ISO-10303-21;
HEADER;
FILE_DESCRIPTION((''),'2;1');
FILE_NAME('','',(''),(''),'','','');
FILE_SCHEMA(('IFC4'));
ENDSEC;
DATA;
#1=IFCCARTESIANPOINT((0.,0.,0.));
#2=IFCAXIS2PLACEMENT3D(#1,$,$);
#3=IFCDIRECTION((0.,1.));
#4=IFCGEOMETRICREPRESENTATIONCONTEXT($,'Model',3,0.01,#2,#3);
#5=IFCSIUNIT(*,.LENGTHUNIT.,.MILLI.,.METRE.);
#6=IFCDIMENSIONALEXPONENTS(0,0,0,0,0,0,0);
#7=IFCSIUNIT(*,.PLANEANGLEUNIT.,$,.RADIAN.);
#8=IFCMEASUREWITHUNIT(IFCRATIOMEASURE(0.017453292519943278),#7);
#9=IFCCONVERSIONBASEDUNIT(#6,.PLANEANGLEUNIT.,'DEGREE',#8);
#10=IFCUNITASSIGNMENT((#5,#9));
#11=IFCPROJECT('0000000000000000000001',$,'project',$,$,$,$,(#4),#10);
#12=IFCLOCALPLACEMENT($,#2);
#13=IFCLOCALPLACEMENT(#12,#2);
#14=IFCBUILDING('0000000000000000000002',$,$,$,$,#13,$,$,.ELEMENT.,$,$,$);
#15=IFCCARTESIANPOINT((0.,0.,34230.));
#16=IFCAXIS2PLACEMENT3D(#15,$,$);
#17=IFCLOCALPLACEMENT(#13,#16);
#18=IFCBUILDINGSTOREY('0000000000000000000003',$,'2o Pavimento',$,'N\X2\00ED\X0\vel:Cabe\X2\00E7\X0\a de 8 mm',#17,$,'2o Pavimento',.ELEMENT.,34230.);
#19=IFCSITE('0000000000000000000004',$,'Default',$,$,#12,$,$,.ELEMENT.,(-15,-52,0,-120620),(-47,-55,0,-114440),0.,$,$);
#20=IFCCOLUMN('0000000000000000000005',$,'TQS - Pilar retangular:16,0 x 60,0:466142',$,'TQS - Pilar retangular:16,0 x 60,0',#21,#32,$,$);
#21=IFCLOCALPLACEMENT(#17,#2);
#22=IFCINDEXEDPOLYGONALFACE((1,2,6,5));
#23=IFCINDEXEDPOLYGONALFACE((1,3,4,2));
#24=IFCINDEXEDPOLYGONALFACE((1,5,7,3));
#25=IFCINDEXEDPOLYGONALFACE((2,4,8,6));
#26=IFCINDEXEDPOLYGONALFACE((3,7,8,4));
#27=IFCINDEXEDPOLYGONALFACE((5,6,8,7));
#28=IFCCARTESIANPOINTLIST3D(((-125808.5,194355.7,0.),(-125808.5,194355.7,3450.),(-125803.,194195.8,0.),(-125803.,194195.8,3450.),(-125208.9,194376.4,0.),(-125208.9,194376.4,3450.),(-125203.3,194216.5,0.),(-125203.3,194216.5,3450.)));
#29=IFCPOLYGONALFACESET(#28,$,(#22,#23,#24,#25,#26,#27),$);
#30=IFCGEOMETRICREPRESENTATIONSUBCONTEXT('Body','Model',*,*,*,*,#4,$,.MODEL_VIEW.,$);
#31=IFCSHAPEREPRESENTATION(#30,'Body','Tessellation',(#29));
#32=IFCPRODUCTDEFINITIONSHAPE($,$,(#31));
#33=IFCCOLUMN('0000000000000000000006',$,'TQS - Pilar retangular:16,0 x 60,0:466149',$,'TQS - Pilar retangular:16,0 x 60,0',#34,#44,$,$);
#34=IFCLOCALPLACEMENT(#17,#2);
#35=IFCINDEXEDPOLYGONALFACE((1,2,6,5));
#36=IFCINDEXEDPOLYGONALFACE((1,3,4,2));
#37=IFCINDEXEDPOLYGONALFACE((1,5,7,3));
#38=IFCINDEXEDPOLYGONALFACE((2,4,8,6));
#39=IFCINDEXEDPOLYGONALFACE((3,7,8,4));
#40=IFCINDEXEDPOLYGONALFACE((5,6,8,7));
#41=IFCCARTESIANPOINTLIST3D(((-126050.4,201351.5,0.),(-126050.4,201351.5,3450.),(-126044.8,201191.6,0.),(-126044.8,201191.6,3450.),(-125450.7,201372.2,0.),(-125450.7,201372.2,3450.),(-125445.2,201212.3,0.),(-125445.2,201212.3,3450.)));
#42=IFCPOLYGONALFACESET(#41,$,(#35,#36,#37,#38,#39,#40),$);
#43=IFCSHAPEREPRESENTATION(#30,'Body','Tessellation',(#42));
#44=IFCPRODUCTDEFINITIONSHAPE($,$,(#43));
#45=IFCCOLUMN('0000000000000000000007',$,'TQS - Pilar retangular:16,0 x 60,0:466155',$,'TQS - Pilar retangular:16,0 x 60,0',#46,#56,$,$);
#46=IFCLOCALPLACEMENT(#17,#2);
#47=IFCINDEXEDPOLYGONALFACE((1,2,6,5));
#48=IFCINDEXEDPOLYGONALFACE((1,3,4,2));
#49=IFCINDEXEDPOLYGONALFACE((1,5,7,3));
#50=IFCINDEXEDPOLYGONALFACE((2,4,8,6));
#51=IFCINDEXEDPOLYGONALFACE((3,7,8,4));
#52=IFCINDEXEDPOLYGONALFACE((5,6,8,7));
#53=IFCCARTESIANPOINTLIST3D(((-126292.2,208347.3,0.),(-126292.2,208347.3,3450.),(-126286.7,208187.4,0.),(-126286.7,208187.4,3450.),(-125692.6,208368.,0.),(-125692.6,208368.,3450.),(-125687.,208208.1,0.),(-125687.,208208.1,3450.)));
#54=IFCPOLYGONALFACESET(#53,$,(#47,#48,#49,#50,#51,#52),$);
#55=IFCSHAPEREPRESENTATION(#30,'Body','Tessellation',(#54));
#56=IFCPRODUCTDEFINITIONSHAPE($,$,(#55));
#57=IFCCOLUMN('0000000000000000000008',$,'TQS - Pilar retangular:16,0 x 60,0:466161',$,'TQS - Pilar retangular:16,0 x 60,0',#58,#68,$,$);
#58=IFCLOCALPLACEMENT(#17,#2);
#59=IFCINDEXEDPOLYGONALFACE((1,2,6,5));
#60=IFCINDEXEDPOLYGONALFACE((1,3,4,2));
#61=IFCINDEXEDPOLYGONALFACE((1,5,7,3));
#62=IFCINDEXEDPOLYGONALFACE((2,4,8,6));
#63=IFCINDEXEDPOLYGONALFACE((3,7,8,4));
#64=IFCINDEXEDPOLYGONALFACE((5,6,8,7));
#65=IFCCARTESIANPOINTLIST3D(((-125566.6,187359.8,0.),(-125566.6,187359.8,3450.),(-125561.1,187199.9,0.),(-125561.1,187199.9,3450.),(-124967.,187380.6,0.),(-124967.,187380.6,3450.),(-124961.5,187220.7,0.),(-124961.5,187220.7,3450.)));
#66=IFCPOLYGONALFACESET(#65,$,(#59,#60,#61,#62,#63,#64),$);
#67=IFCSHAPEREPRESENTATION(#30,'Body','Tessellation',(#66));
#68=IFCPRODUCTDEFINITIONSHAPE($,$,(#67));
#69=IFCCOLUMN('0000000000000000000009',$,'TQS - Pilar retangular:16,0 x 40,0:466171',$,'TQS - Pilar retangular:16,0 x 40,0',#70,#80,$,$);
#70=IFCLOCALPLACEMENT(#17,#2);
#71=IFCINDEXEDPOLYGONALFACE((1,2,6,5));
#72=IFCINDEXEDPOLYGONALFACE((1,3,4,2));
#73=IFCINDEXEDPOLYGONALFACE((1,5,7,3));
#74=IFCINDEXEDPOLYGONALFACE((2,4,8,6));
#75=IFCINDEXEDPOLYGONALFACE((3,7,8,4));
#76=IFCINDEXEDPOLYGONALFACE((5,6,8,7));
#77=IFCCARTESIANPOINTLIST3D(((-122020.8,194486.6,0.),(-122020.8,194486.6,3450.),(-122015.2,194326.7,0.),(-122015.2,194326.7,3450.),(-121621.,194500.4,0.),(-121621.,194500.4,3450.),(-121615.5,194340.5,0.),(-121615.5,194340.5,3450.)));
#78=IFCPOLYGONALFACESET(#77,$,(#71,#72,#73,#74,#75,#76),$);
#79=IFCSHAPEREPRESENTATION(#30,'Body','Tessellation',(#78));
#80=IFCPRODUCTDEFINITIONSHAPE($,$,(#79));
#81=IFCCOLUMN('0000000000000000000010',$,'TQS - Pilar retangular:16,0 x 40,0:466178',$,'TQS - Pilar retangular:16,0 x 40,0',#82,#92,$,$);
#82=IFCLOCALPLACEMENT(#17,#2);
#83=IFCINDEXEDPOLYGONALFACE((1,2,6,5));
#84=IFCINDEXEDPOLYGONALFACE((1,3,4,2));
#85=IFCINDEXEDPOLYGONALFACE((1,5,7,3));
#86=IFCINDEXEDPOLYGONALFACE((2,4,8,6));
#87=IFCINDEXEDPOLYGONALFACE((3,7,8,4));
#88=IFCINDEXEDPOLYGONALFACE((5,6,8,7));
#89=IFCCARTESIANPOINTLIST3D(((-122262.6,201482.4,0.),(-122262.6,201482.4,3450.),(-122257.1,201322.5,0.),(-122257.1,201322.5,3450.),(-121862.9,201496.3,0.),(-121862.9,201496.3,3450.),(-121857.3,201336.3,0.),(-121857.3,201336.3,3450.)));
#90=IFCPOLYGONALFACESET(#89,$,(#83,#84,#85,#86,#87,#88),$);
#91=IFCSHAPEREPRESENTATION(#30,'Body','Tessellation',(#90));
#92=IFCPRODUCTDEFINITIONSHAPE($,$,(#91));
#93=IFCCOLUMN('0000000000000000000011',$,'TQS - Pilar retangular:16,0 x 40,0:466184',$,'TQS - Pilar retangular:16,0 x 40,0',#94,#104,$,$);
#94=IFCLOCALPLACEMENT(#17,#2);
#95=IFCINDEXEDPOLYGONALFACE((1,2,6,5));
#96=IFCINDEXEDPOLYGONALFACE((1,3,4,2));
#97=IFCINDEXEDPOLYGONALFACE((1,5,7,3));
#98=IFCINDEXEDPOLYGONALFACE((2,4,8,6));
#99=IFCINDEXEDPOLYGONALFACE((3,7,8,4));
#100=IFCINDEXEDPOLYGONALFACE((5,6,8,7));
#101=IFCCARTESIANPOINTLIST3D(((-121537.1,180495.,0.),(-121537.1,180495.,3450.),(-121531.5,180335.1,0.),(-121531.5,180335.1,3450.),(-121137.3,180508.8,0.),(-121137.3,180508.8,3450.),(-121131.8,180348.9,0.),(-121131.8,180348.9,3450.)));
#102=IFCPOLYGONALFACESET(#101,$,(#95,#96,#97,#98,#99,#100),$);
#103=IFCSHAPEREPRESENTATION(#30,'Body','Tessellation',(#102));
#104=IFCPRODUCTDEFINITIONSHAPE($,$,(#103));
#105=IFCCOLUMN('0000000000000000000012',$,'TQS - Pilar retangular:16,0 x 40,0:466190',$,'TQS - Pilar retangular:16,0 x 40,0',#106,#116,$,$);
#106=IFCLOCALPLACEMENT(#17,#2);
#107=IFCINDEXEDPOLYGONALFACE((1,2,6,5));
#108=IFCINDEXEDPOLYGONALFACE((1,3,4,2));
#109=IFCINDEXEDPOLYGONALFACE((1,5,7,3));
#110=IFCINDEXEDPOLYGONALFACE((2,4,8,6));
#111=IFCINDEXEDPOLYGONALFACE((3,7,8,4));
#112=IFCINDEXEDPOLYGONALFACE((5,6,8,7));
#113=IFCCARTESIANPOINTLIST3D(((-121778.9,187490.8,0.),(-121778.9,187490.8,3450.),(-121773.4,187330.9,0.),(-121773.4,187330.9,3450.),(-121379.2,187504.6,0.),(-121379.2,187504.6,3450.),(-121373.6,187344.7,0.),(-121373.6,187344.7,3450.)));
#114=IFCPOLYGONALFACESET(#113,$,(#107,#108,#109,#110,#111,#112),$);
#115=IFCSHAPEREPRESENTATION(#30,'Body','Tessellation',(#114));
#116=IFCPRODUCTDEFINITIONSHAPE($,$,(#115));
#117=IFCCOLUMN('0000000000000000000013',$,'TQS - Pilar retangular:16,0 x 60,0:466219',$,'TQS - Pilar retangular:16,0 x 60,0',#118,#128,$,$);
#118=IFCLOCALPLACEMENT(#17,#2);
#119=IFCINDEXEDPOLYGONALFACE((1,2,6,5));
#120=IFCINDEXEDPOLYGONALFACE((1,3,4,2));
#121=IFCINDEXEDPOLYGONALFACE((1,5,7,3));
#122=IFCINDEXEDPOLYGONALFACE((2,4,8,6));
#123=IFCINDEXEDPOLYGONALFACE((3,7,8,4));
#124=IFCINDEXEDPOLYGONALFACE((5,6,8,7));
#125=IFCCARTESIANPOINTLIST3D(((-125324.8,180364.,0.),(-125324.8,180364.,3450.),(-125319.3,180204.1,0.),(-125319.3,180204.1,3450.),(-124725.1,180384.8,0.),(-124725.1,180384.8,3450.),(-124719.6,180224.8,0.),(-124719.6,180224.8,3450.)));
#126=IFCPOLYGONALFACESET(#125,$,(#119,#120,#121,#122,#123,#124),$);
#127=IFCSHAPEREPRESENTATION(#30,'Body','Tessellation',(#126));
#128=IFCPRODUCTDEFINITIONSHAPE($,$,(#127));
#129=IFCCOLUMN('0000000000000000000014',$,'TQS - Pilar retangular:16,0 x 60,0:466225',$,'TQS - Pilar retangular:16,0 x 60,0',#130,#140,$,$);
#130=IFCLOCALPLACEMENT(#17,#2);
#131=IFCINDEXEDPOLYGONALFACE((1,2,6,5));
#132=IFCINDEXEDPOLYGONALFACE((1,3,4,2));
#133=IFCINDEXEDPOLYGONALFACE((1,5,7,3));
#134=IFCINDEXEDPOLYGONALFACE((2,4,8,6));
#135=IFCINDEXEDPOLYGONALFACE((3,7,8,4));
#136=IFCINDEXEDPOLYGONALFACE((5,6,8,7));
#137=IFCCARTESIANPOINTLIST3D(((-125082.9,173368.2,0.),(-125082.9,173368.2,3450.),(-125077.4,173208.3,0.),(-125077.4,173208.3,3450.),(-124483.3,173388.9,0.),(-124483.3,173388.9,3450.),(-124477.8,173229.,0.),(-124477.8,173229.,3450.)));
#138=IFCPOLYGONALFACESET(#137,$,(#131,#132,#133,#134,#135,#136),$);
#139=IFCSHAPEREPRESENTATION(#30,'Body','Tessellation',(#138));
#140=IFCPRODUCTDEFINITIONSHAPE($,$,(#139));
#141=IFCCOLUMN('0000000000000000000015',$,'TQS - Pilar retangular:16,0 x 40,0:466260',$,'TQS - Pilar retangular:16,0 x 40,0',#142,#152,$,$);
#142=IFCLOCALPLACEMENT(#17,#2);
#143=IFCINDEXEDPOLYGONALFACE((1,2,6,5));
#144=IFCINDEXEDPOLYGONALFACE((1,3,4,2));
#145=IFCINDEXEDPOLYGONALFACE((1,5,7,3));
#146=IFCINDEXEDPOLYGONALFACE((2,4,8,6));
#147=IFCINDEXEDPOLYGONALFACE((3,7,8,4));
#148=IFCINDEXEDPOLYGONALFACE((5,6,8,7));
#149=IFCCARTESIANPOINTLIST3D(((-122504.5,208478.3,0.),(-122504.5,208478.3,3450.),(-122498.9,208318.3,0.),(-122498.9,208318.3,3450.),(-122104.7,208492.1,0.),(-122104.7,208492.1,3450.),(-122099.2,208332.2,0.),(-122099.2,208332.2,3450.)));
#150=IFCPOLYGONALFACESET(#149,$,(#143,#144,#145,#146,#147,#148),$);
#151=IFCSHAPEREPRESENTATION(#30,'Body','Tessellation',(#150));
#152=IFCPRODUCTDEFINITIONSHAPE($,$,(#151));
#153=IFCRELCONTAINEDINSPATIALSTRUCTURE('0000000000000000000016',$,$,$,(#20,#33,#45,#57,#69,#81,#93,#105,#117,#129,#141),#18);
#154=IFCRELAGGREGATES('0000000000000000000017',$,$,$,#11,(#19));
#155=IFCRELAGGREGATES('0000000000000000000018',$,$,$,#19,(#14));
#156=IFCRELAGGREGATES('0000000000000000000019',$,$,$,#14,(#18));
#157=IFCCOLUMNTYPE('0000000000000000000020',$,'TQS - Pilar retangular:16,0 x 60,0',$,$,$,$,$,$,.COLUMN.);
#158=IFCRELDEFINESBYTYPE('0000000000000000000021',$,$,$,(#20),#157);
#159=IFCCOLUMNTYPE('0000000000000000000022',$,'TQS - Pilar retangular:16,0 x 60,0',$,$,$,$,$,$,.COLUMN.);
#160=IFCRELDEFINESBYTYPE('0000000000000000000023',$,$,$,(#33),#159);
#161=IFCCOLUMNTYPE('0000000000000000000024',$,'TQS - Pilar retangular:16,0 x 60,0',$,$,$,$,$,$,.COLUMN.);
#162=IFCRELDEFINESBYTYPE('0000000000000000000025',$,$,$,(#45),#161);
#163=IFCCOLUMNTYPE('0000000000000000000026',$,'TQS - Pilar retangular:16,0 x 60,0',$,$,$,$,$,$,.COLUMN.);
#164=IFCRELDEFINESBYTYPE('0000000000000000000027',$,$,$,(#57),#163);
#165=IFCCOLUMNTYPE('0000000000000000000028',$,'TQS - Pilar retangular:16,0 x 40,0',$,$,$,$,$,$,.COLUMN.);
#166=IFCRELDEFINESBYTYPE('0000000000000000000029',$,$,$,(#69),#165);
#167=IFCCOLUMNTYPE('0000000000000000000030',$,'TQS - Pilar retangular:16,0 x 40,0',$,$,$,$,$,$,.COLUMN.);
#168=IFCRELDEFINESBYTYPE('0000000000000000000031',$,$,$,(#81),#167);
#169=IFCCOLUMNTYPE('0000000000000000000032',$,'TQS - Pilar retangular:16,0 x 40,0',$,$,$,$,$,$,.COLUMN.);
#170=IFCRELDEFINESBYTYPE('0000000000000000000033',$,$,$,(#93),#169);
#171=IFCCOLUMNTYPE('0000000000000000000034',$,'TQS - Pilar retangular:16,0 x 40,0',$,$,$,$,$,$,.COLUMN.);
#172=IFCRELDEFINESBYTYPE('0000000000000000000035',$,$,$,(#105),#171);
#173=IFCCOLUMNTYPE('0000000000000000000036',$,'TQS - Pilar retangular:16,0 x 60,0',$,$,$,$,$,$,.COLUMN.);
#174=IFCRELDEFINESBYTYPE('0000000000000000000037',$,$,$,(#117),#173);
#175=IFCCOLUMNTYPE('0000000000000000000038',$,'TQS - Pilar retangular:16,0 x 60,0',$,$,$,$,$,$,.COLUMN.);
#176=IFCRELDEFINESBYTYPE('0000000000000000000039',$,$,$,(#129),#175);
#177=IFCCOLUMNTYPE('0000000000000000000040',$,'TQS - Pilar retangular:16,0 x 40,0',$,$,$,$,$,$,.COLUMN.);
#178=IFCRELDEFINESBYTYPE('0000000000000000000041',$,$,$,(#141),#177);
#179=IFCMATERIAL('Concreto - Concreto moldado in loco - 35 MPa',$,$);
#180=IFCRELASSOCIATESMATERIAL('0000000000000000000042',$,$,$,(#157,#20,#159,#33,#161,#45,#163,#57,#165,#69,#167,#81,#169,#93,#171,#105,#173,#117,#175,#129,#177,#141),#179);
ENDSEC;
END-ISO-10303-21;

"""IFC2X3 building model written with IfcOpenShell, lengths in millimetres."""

from ifc_helpers import new_model, entity, si_unit, converted_unit, direction, frame, origin, origin_2d_with_axis, place, context, subcontext, project, spatial, rectangle, extrude, source, transform, mapped, material, type_object, type_shapes, element, save


model = new_model("IFC2X3")

# Units and contexts
model_context = context("Model", 3, precision=0.01, world=origin(), true_north=direction((0.0, 1.0)))
body_context = subcontext(model_context, "Body", "Model", "MODEL_VIEW")
ifc_project = project(units=[si_unit("LENGTHUNIT", "METRE", prefix="MILLI"), converted_unit("PLANEANGLEUNIT", "DEGREE", entity("IfcRatioMeasure", 0.017453292519943278), si_unit("PLANEANGLEUNIT", "RADIAN"), dimensions=[0, 0, 0, 0, 0, 0, 0])], contexts=[model_context])

# Site, building, storey
site_placement = place(None, origin())
site = spatial("IfcSite", under=ifc_project, at=site_placement, Name="Default", CompositionType="ELEMENT", RefLatitude=(-15, -52, 0, -120620), RefLongitude=(-47, -55, 0, -114440), RefElevation=0.0)
building_placement = place(site_placement, origin())
building = spatial("IfcBuilding", under=site, at=building_placement, CompositionType="ELEMENT")
storey_placement = place(building_placement, frame((0.0, 0.0, 34230.0)))
storey = spatial("IfcBuildingStorey", under=building, at=storey_placement, Name="2o Pavimento", ObjectType="Nível:Cabeça de 8 mm", LongName="2o Pavimento", CompositionType="ELEMENT", Elevation=34230.0)

# Columns
ifc_material = material(Name="Concreto - Concreto moldado in loco - 35 MPa")
column_type_1 = type_object("IfcColumnType", Name="TQS - Pilar retangular:16,0 x 60,0", PredefinedType="COLUMN", material=ifc_material)
shared_shape_1 = source(origin(), body_context, "Body", "SweptSolid", [
    extrude(rectangle(XDim=600.0, YDim=160.0, at=origin_2d_with_axis()), frame((-125505.9, 194286.1, 34230.0), z_axis=(0.0, 0.0, 1.0), x_axis=(-0.999403, -0.034551, 0.0)), (0.0, 0.0, 1.0), 3450.0),
])
type_shapes(column_type_1, [shared_shape_1])
column_1_placement = place(storey_placement, frame((0.0, 0.0, -34230.0)))
element("IfcColumn", 1, at=column_1_placement, inside=storey, type_object=column_type_1, material=ifc_material, Name="TQS - Pilar retangular:16,0 x 60,0:466142", ObjectType="TQS - Pilar retangular:16,0 x 60,0", context=body_context, shape_type="MappedRepresentation", body=[
    mapped(shared_shape_1, transform((0.0, 0.0, 0.0), scale=1.0)),
])
column_type_2 = type_object("IfcColumnType", Name="TQS - Pilar retangular:16,0 x 60,0", PredefinedType="COLUMN", material=ifc_material)
shared_shape_2 = source(origin(), body_context, "Body", "SweptSolid", [
    extrude(rectangle(XDim=600.0, YDim=160.0, at=origin_2d_with_axis()), frame((-125747.8, 201281.9, 34230.0), z_axis=(0.0, 0.0, 1.0), x_axis=(-0.999403, -0.034551, 0.0)), (0.0, 0.0, 1.0), 3450.0),
])
type_shapes(column_type_2, [shared_shape_2])
column_2_placement = place(storey_placement, frame((0.0, 0.0, -34230.0)))
element("IfcColumn", 2, at=column_2_placement, inside=storey, type_object=column_type_2, material=ifc_material, Name="TQS - Pilar retangular:16,0 x 60,0:466149", ObjectType="TQS - Pilar retangular:16,0 x 60,0", context=body_context, shape_type="MappedRepresentation", body=[
    mapped(shared_shape_2, transform((0.0, 0.0, 0.0), scale=1.0)),
])
column_type_3 = type_object("IfcColumnType", Name="TQS - Pilar retangular:16,0 x 60,0", PredefinedType="COLUMN", material=ifc_material)
shared_shape_3 = source(origin(), body_context, "Body", "SweptSolid", [
    extrude(rectangle(XDim=600.0, YDim=160.0, at=origin_2d_with_axis()), frame((-125989.6, 208277.7, 34230.0), z_axis=(0.0, 0.0, 1.0), x_axis=(-0.999403, -0.034551, 0.0)), (0.0, 0.0, 1.0), 3450.0),
])
type_shapes(column_type_3, [shared_shape_3])
column_3_placement = place(storey_placement, frame((0.0, 0.0, -34230.0)))
element("IfcColumn", 3, at=column_3_placement, inside=storey, type_object=column_type_3, material=ifc_material, Name="TQS - Pilar retangular:16,0 x 60,0:466155", ObjectType="TQS - Pilar retangular:16,0 x 60,0", context=body_context, shape_type="MappedRepresentation", body=[
    mapped(shared_shape_3, transform((0.0, 0.0, 0.0), scale=1.0)),
])
column_type_4 = type_object("IfcColumnType", Name="TQS - Pilar retangular:16,0 x 60,0", PredefinedType="COLUMN", material=ifc_material)
shared_shape_4 = source(origin(), body_context, "Body", "SweptSolid", [
    extrude(rectangle(XDim=600.0, YDim=160.0, at=origin_2d_with_axis()), frame((-125264.1, 187290.3, 34230.0), z_axis=(0.0, 0.0, 1.0), x_axis=(-0.999403, -0.034551, 0.0)), (0.0, 0.0, 1.0), 3450.0),
])
type_shapes(column_type_4, [shared_shape_4])
column_4_placement = place(storey_placement, frame((0.0, 0.0, -34230.0)))
element("IfcColumn", 4, at=column_4_placement, inside=storey, type_object=column_type_4, material=ifc_material, Name="TQS - Pilar retangular:16,0 x 60,0:466161", ObjectType="TQS - Pilar retangular:16,0 x 60,0", context=body_context, shape_type="MappedRepresentation", body=[
    mapped(shared_shape_4, transform((0.0, 0.0, 0.0), scale=1.0)),
])
column_type_5 = type_object("IfcColumnType", Name="TQS - Pilar retangular:16,0 x 40,0", PredefinedType="COLUMN", material=ifc_material)
shared_shape_5 = source(origin(), body_context, "Body", "SweptSolid", [
    extrude(rectangle(XDim=400.0, YDim=160.0, at=origin_2d_with_axis()), frame((-121818.1, 194413.6, 34230.0), z_axis=(0.0, 0.0, 1.0), x_axis=(-0.999403, -0.034551, 0.0)), (0.0, 0.0, 1.0), 3450.0),
])
type_shapes(column_type_5, [shared_shape_5])
column_5_placement = place(storey_placement, frame((0.0, 0.0, -34230.0)))
element("IfcColumn", 5, at=column_5_placement, inside=storey, type_object=column_type_5, material=ifc_material, Name="TQS - Pilar retangular:16,0 x 40,0:466171", ObjectType="TQS - Pilar retangular:16,0 x 40,0", context=body_context, shape_type="MappedRepresentation", body=[
    mapped(shared_shape_5, transform((0.0, 0.0, 0.0), scale=1.0)),
])
column_type_6 = type_object("IfcColumnType", Name="TQS - Pilar retangular:16,0 x 40,0", PredefinedType="COLUMN", material=ifc_material)
shared_shape_6 = source(origin(), body_context, "Body", "SweptSolid", [
    extrude(rectangle(XDim=400.0, YDim=160.0, at=origin_2d_with_axis()), frame((-122060.0, 201409.4, 34230.0), z_axis=(0.0, 0.0, 1.0), x_axis=(-0.999403, -0.034551, 0.0)), (0.0, 0.0, 1.0), 3450.0),
])
type_shapes(column_type_6, [shared_shape_6])
column_6_placement = place(storey_placement, frame((0.0, 0.0, -34230.0)))
element("IfcColumn", 6, at=column_6_placement, inside=storey, type_object=column_type_6, material=ifc_material, Name="TQS - Pilar retangular:16,0 x 40,0:466178", ObjectType="TQS - Pilar retangular:16,0 x 40,0", context=body_context, shape_type="MappedRepresentation", body=[
    mapped(shared_shape_6, transform((0.0, 0.0, 0.0), scale=1.0)),
])
column_type_7 = type_object("IfcColumnType", Name="TQS - Pilar retangular:16,0 x 40,0", PredefinedType="COLUMN", material=ifc_material)
shared_shape_7 = source(origin(), body_context, "Body", "SweptSolid", [
    extrude(rectangle(XDim=400.0, YDim=160.0, at=origin_2d_with_axis()), frame((-121334.4, 180421.9, 34230.0), z_axis=(0.0, 0.0, 1.0), x_axis=(-0.999403, -0.034551, 0.0)), (0.0, 0.0, 1.0), 3450.0),
])
type_shapes(column_type_7, [shared_shape_7])
column_7_placement = place(storey_placement, frame((0.0, 0.0, -34230.0)))
element("IfcColumn", 7, at=column_7_placement, inside=storey, type_object=column_type_7, material=ifc_material, Name="TQS - Pilar retangular:16,0 x 40,0:466184", ObjectType="TQS - Pilar retangular:16,0 x 40,0", context=body_context, shape_type="MappedRepresentation", body=[
    mapped(shared_shape_7, transform((0.0, 0.0, 0.0), scale=1.0)),
])
column_type_8 = type_object("IfcColumnType", Name="TQS - Pilar retangular:16,0 x 40,0", PredefinedType="COLUMN", material=ifc_material)
shared_shape_8 = source(origin(), body_context, "Body", "SweptSolid", [
    extrude(rectangle(XDim=400.0, YDim=160.0, at=origin_2d_with_axis()), frame((-121576.3, 187417.7, 34230.0), z_axis=(0.0, 0.0, 1.0), x_axis=(-0.999403, -0.034551, 0.0)), (0.0, 0.0, 1.0), 3450.0),
])
type_shapes(column_type_8, [shared_shape_8])
column_8_placement = place(storey_placement, frame((0.0, 0.0, -34230.0)))
element("IfcColumn", 8, at=column_8_placement, inside=storey, type_object=column_type_8, material=ifc_material, Name="TQS - Pilar retangular:16,0 x 40,0:466190", ObjectType="TQS - Pilar retangular:16,0 x 40,0", context=body_context, shape_type="MappedRepresentation", body=[
    mapped(shared_shape_8, transform((0.0, 0.0, 0.0), scale=1.0)),
])
column_type_9 = type_object("IfcColumnType", Name="TQS - Pilar retangular:16,0 x 60,0", PredefinedType="COLUMN", material=ifc_material)
shared_shape_9 = source(origin(), body_context, "Body", "SweptSolid", [
    extrude(rectangle(XDim=600.0, YDim=160.0, at=origin_2d_with_axis()), frame((-125022.2, 180294.4, 34230.0), z_axis=(0.0, 0.0, 1.0), x_axis=(-0.999403, -0.034551, 0.0)), (0.0, 0.0, 1.0), 3450.0),
])
type_shapes(column_type_9, [shared_shape_9])
column_9_placement = place(storey_placement, frame((0.0, 0.0, -34230.0)))
element("IfcColumn", 9, at=column_9_placement, inside=storey, type_object=column_type_9, material=ifc_material, Name="TQS - Pilar retangular:16,0 x 60,0:466219", ObjectType="TQS - Pilar retangular:16,0 x 60,0", context=body_context, shape_type="MappedRepresentation", body=[
    mapped(shared_shape_9, transform((0.0, 0.0, 0.0), scale=1.0)),
])
column_type_10 = type_object("IfcColumnType", Name="TQS - Pilar retangular:16,0 x 60,0", PredefinedType="COLUMN", material=ifc_material)
shared_shape_10 = source(origin(), body_context, "Body", "SweptSolid", [
    extrude(rectangle(XDim=600.0, YDim=160.0, at=origin_2d_with_axis()), frame((-124780.3, 173298.6, 34230.0), z_axis=(0.0, 0.0, 1.0), x_axis=(-0.999403, -0.034551, 0.0)), (0.0, 0.0, 1.0), 3450.0),
])
type_shapes(column_type_10, [shared_shape_10])
column_10_placement = place(storey_placement, frame((0.0, 0.0, -34230.0)))
element("IfcColumn", 10, at=column_10_placement, inside=storey, type_object=column_type_10, material=ifc_material, Name="TQS - Pilar retangular:16,0 x 60,0:466225", ObjectType="TQS - Pilar retangular:16,0 x 60,0", context=body_context, shape_type="MappedRepresentation", body=[
    mapped(shared_shape_10, transform((0.0, 0.0, 0.0), scale=1.0)),
])
column_type_11 = type_object("IfcColumnType", Name="TQS - Pilar retangular:16,0 x 40,0", PredefinedType="COLUMN", material=ifc_material)
shared_shape_11 = source(origin(), body_context, "Body", "SweptSolid", [
    extrude(rectangle(XDim=400.0, YDim=160.0, at=origin_2d_with_axis()), frame((-122301.8, 208405.2, 34230.0), z_axis=(0.0, 0.0, 1.0), x_axis=(-0.999403, -0.034551, 0.0)), (0.0, 0.0, 1.0), 3450.0),
])
type_shapes(column_type_11, [shared_shape_11])
column_11_placement = place(storey_placement, frame((0.0, 0.0, -34230.0)))
element("IfcColumn", 11, at=column_11_placement, inside=storey, type_object=column_type_11, material=ifc_material, Name="TQS - Pilar retangular:16,0 x 40,0:466260", ObjectType="TQS - Pilar retangular:16,0 x 40,0", context=body_context, shape_type="MappedRepresentation", body=[
    mapped(shared_shape_11, transform((0.0, 0.0, 0.0), scale=1.0)),
])

save(model, "model.ifc")
